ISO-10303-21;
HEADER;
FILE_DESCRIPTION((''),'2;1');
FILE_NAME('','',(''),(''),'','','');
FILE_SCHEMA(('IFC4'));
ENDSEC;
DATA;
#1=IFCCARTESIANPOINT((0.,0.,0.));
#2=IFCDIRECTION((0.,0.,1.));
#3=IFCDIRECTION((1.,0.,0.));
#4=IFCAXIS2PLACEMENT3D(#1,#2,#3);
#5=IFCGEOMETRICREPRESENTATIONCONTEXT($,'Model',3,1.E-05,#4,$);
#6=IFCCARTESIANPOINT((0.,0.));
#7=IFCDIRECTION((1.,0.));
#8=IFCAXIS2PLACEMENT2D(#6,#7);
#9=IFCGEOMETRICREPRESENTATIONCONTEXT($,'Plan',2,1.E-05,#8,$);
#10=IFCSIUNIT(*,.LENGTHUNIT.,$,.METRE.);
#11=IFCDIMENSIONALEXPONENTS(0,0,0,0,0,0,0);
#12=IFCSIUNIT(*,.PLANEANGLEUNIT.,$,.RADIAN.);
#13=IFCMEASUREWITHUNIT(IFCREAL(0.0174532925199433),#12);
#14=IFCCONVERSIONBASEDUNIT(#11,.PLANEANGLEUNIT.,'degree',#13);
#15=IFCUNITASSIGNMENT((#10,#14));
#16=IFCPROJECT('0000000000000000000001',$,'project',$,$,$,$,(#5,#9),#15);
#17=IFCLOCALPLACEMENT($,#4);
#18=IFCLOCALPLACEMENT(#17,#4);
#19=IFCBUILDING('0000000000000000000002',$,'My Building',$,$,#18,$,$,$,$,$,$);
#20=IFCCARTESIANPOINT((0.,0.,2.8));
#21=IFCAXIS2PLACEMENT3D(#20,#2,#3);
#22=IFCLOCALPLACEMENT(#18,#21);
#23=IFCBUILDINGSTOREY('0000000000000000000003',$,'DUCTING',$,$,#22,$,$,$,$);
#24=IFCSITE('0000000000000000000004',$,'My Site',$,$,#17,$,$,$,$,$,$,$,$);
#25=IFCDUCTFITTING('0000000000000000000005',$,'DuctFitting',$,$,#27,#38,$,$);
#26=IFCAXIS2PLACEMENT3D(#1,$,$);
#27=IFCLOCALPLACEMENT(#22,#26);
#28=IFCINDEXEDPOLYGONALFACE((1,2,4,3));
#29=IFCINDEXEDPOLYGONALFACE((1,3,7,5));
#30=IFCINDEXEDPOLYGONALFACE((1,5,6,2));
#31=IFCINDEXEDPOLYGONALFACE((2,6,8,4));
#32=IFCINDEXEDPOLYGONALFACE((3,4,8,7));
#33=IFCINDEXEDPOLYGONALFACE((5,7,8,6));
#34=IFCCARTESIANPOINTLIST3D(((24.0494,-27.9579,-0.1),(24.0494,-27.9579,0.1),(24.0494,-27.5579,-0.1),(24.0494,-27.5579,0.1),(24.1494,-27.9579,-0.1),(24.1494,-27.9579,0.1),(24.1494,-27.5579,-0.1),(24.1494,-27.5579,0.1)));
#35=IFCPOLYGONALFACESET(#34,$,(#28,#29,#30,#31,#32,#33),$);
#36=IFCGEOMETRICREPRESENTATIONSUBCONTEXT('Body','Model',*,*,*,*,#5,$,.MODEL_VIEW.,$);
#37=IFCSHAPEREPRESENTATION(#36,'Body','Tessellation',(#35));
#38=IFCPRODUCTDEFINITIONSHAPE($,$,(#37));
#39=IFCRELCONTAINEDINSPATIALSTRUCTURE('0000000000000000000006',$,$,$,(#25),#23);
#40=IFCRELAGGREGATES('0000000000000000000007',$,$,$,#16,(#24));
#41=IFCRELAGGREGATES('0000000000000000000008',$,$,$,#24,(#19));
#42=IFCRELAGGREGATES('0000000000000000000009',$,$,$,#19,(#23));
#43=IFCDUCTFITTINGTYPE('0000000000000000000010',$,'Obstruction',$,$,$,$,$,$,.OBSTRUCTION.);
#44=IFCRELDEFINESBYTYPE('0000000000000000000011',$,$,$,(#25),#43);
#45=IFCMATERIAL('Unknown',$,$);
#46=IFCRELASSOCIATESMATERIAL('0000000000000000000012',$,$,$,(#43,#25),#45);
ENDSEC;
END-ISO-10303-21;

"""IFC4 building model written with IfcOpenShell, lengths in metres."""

from ifc_helpers import new_model, entity, si_unit, converted_unit, frame, origin_with_axes, origin_2d_with_axis, place, context, subcontext, project, spatial, rectangle, extrude, material, material_profile, profile_set, profile_usage, type_object, element, save


model = new_model("IFC4")

# Units and contexts
model_context = context("Model", 3, precision=1e-05, world=origin_with_axes())
plan_context = context("Plan", 2, precision=1e-05, world=origin_2d_with_axis())
body_context = subcontext(model_context, "Body", "Model", "MODEL_VIEW")
ifc_project = project(units=[si_unit("LENGTHUNIT", "METRE"), converted_unit("PLANEANGLEUNIT", "degree", entity("IfcReal", 0.0174532925199433), si_unit("PLANEANGLEUNIT", "RADIAN"), dimensions=[0, 0, 0, 0, 0, 0, 0])], contexts=[model_context, plan_context])

# Site, building, storey
site_placement = place(None, origin_with_axes())
site = spatial("IfcSite", under=ifc_project, at=site_placement, Name="My Site")
building_placement = place(site_placement, origin_with_axes())
building = spatial("IfcBuilding", under=site, at=building_placement, Name="My Building")
storey_placement = place(building_placement, frame((0.0, 0.0, 2.8), z_axis=(0.0, 0.0, 1.0), x_axis=(1.0, 0.0, 0.0)))
storey = spatial("IfcBuildingStorey", under=building, at=storey_placement, Name="DUCTING")

# Shared definitions
ifc_material = material(Name="Unknown")

# Duct fitting
ifc_material_profile_1 = material_profile(ifc_material, rectangle(XDim=0.4, YDim=0.2))
ifc_profile_set_1 = profile_set([ifc_material_profile_1])
duct_fitting_type_1 = type_object("IfcDuctFittingType", Name="Obstruction", PredefinedType="OBSTRUCTION", material=ifc_profile_set_1)
ifc_profile_usage_1 = profile_usage(ifc_profile_set_1, cardinal=5)
duct_fitting_1_placement = place(storey_placement, frame((24.1494, -27.7579, 0.0), z_axis=(-1.0, 0.0, 0.0), x_axis=(0.0, -1.0, 0.0)))
element("IfcDuctFitting", 1, at=duct_fitting_1_placement, inside=storey, type_object=duct_fitting_type_1, material=ifc_profile_usage_1, Name="DuctFitting", context=body_context, shape_type="SweptSolid", body=[
    extrude(rectangle(XDim=0.4, YDim=0.2), origin_with_axes(), (0.0, 0.0, 1.0), 0.1),
])

save(model, "model.ifc")
